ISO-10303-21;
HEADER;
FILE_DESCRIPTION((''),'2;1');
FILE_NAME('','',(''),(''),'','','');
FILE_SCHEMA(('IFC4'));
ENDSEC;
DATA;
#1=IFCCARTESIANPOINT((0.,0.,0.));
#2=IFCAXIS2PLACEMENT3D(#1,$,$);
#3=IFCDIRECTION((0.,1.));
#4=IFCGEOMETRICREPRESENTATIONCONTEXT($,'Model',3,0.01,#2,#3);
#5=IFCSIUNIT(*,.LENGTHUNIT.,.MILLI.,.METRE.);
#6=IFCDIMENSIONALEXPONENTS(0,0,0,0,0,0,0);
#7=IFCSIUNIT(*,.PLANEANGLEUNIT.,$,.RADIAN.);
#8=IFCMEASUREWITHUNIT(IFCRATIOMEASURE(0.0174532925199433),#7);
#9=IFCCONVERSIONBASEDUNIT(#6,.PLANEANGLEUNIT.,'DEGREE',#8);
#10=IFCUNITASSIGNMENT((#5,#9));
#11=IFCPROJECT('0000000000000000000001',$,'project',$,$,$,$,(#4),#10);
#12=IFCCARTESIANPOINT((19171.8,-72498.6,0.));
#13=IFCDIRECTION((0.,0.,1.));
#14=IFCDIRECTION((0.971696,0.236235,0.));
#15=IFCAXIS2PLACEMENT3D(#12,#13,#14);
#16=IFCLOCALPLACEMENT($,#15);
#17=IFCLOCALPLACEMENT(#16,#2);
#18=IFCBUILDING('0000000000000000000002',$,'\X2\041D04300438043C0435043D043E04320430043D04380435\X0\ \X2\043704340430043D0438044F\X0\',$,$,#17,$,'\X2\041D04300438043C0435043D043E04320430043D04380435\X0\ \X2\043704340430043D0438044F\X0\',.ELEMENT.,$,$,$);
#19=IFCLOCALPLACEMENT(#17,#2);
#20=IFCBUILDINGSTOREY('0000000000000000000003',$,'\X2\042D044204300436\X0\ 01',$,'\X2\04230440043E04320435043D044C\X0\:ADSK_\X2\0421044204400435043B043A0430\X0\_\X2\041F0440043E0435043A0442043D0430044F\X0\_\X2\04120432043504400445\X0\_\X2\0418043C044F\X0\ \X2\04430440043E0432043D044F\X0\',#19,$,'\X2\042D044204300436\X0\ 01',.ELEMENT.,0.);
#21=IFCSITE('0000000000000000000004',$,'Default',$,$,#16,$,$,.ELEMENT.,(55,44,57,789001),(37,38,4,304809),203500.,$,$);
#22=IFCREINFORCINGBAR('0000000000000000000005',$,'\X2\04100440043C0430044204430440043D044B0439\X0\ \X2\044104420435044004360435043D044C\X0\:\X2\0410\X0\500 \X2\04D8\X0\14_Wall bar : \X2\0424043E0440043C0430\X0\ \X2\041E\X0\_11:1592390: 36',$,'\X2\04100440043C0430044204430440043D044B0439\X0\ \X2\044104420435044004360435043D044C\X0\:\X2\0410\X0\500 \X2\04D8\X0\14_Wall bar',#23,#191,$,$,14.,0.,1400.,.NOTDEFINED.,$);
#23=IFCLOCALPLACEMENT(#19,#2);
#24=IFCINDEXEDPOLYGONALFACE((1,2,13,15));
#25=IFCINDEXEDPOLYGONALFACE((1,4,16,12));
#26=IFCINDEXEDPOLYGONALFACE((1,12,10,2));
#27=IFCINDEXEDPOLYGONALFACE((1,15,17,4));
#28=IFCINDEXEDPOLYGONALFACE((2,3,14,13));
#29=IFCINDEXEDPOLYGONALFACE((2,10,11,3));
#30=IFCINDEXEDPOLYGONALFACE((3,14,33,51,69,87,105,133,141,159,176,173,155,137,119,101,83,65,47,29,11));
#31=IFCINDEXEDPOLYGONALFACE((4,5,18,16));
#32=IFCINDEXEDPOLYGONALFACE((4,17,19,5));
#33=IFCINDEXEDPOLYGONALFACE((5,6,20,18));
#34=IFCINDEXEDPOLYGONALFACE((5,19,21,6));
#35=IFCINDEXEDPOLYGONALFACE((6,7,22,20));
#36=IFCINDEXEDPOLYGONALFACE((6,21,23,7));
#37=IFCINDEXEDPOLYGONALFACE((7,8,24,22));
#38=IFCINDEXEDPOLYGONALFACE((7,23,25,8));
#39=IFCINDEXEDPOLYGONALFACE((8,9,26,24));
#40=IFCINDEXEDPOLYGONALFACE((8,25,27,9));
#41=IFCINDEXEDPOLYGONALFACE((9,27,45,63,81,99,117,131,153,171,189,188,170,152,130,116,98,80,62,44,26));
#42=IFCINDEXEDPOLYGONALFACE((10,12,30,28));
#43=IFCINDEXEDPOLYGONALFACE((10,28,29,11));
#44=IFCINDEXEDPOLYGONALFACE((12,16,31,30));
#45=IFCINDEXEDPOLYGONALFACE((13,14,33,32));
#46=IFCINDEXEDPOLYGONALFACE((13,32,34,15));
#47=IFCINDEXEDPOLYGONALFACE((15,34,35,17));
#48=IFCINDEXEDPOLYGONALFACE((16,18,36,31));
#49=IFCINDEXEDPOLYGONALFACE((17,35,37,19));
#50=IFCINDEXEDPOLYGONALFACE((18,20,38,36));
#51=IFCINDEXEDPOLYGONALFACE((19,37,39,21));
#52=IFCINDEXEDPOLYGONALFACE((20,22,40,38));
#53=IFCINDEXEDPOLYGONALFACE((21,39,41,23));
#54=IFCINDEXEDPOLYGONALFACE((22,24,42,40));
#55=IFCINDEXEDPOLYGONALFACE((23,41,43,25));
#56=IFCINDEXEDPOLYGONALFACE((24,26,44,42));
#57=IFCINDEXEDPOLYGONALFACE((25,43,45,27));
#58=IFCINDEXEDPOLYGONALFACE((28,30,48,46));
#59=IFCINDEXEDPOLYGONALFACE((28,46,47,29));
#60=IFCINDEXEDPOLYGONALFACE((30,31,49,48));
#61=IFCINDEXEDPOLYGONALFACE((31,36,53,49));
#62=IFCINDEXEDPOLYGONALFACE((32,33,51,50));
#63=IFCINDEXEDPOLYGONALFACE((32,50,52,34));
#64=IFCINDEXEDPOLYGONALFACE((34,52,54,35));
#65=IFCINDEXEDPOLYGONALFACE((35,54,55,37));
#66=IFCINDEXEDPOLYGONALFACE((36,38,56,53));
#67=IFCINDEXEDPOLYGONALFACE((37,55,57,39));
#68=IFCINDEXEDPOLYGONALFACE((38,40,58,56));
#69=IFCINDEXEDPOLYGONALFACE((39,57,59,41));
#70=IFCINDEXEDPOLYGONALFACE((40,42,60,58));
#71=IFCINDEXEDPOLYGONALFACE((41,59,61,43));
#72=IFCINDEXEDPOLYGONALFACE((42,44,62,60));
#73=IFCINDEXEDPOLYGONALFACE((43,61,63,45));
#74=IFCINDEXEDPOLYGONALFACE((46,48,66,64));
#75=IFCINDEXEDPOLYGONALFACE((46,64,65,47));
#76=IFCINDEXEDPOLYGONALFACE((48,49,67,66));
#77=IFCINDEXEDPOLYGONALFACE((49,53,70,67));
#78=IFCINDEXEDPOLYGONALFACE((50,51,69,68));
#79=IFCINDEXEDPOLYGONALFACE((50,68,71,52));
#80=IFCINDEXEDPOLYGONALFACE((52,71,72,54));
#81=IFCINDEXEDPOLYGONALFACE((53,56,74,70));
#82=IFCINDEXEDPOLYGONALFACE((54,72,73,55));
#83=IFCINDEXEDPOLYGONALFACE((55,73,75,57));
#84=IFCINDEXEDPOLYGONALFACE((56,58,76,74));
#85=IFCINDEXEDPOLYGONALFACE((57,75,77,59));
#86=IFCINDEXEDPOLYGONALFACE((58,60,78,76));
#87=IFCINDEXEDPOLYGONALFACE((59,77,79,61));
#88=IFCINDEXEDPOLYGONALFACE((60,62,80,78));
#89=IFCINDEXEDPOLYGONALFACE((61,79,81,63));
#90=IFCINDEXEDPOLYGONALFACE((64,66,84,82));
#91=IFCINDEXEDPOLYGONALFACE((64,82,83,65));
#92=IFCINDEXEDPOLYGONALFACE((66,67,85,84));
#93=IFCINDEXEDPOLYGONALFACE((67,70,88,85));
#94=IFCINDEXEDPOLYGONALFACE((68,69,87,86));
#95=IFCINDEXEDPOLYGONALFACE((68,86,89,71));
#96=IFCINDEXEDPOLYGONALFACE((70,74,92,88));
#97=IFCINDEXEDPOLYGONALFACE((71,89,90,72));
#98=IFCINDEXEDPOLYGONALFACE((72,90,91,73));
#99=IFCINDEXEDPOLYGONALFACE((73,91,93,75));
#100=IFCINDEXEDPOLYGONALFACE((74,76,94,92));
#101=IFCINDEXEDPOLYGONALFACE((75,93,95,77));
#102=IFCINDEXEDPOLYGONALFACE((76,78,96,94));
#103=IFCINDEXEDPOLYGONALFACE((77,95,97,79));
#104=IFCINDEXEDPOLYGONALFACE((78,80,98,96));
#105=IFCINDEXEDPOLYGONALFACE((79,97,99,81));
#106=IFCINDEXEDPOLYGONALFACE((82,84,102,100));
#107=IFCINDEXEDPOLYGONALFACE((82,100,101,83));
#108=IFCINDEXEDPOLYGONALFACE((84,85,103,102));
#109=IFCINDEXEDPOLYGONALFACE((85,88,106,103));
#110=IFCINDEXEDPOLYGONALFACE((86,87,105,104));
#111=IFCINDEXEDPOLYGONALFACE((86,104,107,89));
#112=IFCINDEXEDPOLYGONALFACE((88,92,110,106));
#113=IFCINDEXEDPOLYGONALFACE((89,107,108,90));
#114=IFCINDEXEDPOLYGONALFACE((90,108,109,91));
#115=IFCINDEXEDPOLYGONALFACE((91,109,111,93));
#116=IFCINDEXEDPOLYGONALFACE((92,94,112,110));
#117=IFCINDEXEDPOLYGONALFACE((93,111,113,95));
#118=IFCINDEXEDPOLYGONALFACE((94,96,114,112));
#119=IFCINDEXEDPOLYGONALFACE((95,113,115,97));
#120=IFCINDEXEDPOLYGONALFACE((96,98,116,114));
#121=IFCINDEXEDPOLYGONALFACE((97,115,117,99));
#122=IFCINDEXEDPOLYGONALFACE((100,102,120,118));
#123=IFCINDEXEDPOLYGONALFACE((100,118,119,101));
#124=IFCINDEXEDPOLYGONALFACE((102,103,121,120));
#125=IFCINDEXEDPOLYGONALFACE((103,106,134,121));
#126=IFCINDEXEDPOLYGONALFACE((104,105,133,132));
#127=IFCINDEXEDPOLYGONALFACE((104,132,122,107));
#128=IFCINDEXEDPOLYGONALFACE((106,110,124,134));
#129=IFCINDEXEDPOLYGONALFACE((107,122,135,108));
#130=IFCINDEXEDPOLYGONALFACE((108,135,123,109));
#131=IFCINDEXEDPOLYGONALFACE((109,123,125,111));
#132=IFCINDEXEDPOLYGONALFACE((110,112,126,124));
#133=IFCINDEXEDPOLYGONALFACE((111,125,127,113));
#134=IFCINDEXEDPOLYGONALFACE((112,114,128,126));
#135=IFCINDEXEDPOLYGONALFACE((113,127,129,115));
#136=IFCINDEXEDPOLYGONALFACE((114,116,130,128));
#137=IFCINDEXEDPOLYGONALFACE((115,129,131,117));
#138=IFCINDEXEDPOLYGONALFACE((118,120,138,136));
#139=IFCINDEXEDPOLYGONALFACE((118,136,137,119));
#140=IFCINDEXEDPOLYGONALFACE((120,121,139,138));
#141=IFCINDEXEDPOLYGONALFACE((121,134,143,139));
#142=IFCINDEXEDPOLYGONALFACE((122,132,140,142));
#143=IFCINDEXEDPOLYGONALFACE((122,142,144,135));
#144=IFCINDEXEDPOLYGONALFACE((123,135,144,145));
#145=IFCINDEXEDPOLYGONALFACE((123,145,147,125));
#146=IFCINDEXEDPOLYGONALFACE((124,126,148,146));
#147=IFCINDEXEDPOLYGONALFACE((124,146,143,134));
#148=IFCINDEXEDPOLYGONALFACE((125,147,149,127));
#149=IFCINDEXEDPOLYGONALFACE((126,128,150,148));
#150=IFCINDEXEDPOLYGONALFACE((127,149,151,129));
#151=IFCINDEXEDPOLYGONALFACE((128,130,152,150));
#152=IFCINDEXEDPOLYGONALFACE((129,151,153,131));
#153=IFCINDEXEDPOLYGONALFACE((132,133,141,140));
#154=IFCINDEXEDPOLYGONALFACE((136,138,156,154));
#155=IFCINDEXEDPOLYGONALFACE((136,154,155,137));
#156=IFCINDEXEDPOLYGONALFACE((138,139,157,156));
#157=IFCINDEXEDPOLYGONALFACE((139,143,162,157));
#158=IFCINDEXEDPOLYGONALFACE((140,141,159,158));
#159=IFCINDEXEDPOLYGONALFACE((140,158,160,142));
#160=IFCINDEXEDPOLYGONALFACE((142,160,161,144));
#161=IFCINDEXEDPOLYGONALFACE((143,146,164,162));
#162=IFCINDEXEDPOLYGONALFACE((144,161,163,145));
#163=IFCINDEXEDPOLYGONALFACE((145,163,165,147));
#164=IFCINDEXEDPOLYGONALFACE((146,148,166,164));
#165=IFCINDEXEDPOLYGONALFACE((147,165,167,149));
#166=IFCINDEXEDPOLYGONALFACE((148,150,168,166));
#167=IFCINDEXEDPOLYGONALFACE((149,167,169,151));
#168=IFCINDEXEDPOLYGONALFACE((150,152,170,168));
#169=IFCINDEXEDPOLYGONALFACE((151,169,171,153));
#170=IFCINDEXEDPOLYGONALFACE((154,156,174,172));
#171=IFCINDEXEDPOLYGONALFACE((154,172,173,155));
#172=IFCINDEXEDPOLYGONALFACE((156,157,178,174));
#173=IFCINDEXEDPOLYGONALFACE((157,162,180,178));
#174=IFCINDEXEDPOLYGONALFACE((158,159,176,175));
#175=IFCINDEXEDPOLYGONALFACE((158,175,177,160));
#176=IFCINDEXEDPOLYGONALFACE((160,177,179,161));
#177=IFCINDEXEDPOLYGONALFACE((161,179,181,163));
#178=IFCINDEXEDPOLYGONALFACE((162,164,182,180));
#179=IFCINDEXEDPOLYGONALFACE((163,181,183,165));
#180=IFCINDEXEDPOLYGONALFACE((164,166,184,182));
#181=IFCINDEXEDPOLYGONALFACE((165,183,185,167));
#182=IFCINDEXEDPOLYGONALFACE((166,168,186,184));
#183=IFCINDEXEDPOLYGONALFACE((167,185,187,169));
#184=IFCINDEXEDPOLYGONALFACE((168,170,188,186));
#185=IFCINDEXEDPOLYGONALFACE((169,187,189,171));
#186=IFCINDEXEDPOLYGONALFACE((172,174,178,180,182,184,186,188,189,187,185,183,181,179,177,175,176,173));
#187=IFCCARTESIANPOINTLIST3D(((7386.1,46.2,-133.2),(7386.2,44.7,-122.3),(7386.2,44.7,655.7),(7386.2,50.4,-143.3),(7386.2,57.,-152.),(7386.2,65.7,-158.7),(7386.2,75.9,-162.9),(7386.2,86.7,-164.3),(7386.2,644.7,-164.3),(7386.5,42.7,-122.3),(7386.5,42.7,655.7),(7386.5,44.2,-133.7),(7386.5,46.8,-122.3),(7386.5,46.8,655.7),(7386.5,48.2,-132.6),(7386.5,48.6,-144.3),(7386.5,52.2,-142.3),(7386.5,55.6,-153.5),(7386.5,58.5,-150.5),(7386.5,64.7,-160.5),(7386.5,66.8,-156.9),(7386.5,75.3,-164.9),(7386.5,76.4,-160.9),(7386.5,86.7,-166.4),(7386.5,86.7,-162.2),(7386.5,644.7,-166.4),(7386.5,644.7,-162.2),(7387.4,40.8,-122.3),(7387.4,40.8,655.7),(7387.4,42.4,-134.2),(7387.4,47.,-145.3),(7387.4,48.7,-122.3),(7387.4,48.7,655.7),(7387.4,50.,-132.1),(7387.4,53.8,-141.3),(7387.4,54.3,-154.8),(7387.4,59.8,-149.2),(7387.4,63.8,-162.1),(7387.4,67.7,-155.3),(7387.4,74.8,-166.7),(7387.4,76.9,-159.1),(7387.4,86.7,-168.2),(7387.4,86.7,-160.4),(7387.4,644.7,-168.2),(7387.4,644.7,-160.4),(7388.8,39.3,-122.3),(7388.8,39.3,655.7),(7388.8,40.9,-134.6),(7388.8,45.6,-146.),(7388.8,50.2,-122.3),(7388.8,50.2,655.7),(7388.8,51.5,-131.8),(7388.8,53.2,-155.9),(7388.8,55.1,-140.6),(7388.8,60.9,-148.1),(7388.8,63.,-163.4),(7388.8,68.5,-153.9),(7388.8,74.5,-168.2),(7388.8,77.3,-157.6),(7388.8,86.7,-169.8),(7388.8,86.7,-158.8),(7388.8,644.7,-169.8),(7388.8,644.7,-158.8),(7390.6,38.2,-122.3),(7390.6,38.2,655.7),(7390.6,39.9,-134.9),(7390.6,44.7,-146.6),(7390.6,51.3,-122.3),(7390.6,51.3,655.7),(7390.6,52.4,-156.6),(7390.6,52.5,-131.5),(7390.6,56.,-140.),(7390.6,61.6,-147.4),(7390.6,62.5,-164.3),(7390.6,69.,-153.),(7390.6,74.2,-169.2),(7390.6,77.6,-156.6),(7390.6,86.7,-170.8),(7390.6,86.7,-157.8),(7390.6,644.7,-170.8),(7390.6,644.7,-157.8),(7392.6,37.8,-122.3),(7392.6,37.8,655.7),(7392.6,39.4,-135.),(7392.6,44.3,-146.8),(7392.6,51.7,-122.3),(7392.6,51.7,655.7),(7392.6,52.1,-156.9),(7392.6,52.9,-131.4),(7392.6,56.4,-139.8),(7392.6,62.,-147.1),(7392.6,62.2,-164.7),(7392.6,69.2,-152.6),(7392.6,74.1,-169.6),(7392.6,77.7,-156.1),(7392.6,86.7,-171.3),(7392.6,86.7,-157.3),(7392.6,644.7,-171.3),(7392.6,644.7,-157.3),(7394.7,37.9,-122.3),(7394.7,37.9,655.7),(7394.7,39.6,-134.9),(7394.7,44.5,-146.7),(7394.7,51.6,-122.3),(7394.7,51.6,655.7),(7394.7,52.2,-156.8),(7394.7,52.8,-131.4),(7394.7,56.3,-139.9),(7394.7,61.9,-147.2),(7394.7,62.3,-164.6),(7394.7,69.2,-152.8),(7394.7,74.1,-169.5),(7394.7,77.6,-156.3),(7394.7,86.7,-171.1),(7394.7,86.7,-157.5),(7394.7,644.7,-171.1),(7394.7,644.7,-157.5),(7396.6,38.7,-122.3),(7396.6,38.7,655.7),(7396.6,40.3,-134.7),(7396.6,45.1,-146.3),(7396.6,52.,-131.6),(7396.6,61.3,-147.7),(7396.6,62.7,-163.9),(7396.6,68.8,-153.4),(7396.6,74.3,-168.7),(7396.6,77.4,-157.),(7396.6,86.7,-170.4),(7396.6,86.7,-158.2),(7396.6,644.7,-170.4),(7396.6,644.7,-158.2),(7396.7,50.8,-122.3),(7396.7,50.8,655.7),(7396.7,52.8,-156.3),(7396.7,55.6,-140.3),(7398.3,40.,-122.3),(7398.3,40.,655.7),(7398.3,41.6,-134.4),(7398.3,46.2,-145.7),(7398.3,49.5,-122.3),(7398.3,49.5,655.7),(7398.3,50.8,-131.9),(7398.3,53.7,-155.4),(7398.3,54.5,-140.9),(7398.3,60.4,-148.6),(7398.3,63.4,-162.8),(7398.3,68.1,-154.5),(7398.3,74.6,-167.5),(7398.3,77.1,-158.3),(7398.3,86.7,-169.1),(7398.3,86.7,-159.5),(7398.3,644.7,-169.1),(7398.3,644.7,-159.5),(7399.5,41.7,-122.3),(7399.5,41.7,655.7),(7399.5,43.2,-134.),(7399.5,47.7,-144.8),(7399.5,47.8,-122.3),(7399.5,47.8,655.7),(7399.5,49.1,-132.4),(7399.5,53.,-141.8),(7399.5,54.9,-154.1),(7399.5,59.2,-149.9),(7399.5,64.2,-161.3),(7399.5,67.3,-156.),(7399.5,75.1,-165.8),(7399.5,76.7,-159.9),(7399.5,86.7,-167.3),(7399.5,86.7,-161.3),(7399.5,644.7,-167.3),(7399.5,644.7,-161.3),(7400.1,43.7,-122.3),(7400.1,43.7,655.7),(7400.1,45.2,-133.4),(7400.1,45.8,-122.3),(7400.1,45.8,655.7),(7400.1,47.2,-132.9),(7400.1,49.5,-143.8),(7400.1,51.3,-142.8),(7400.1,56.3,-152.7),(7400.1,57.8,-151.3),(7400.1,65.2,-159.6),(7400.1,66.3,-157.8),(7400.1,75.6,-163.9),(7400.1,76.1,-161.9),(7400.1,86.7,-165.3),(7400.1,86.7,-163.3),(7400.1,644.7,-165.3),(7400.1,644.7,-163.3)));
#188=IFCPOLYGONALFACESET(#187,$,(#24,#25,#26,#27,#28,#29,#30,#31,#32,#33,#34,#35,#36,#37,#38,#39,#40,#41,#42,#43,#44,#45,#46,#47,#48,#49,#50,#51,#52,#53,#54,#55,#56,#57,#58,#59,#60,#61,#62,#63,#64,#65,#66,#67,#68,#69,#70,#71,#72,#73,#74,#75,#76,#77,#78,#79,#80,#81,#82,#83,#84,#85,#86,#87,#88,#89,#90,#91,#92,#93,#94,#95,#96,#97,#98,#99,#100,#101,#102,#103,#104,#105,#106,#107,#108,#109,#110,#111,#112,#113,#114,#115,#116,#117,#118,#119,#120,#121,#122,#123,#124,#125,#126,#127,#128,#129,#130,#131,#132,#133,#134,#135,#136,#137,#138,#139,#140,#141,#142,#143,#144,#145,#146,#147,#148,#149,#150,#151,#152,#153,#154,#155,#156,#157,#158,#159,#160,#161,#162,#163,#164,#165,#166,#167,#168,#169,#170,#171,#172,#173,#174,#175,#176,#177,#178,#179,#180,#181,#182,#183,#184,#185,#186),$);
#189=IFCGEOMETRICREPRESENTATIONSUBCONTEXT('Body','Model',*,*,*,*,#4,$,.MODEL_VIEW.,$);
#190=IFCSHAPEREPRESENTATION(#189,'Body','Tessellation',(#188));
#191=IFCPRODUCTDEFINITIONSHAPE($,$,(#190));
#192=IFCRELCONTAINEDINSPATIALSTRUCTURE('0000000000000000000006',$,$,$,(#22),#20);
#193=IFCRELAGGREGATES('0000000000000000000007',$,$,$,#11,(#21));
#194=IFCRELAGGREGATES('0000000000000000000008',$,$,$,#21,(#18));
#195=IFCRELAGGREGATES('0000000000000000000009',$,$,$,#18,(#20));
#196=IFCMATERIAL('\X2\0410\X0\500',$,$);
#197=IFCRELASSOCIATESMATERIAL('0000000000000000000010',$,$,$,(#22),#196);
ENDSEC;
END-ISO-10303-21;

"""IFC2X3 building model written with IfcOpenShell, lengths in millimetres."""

from ifc_helpers import new_model, entity, si_unit, converted_unit, direction, frame, origin, place, context, subcontext, project, spatial, material, element, save


model = new_model("IFC2X3")

# Units and contexts
model_context = context("Model", 3, precision=0.01, world=origin(), true_north=direction((0.0, 1.0)))
body_context = subcontext(model_context, "Body", "Model", "MODEL_VIEW")
ifc_project = project(units=[si_unit("LENGTHUNIT", "METRE", prefix="MILLI"), converted_unit("PLANEANGLEUNIT", "DEGREE", entity("IfcRatioMeasure", 0.0174532925199433), si_unit("PLANEANGLEUNIT", "RADIAN"), dimensions=[0, 0, 0, 0, 0, 0, 0])], contexts=[model_context])

# Site, building, storey
site_placement = place(None, frame((19171.8, -72498.6, 0.0), z_axis=(0.0, 0.0, 1.0), x_axis=(0.971696, 0.236235, 0.0)))
site = spatial("IfcSite", under=ifc_project, at=site_placement, Name="Default", CompositionType="ELEMENT", RefLatitude=(55, 44, 57, 789001), RefLongitude=(37, 38, 4, 304809), RefElevation=203500.0)
building_placement = place(site_placement, origin())
building = spatial("IfcBuilding", under=site, at=building_placement, Name="Наименование здания", LongName="Наименование здания", CompositionType="ELEMENT")
storey_placement = place(building_placement, origin())
storey = spatial("IfcBuildingStorey", under=building, at=storey_placement, Name="Этаж 01", ObjectType="Уровень:ADSK_Стрелка_Проектная_Вверх_Имя уровня", LongName="Этаж 01", CompositionType="ELEMENT", Elevation=0.0)

# Reinforcing bar
ifc_material = material(Name="А500")
placement = place(storey_placement, origin())
element("IfcReinforcingBar", 1, at=placement, inside=storey, material=ifc_material, Name="Арматурный стержень:А500 Ә14_Wall bar : Форма О_11:1592390: 36", ObjectType="Арматурный стержень:А500 Ә14_Wall bar", BarLength=1400.0, BarRole="NOTDEFINED", CrossSectionArea=0.0, NominalDiameter=14.0, context=body_context, shape_type="AdvancedSweptSolid", body=[
    entity("IfcSweptDiskSolid", entity("IfcCompositeCurve", [entity("IfcCompositeCurveSegment", "CONTINUOUS", True, entity("IfcPolyline", [entity("IfcCartesianPoint", [7393.1, 44.7, 655.7]), entity("IfcCartesianPoint", [7393.1, 44.7, -122.3])])), entity("IfcCompositeCurveSegment", "CONTINUOUS", True, entity("IfcTrimmedCurve", entity("IfcCircle", entity("IfcAxis2Placement3D", entity("IfcCartesianPoint", [7393.1, 86.7, -122.3]), entity("IfcDirection", [1.0, 0.0, 0.0]), entity("IfcDirection", [0.0, 0.0, -1.0])), 42.0), [entity("IfcParameterValue", 270.0)], [entity("IfcParameterValue", 360.0)], True, "PARAMETER")), entity("IfcCompositeCurveSegment", "CONTINUOUS", True, entity("IfcPolyline", [entity("IfcCartesianPoint", [7393.1, 86.7, -164.3]), entity("IfcCartesianPoint", [7393.1, 644.7, -164.3])]))], False), 7.0, None, 0.0, 92.0),
])

save(model, "model.ifc")
